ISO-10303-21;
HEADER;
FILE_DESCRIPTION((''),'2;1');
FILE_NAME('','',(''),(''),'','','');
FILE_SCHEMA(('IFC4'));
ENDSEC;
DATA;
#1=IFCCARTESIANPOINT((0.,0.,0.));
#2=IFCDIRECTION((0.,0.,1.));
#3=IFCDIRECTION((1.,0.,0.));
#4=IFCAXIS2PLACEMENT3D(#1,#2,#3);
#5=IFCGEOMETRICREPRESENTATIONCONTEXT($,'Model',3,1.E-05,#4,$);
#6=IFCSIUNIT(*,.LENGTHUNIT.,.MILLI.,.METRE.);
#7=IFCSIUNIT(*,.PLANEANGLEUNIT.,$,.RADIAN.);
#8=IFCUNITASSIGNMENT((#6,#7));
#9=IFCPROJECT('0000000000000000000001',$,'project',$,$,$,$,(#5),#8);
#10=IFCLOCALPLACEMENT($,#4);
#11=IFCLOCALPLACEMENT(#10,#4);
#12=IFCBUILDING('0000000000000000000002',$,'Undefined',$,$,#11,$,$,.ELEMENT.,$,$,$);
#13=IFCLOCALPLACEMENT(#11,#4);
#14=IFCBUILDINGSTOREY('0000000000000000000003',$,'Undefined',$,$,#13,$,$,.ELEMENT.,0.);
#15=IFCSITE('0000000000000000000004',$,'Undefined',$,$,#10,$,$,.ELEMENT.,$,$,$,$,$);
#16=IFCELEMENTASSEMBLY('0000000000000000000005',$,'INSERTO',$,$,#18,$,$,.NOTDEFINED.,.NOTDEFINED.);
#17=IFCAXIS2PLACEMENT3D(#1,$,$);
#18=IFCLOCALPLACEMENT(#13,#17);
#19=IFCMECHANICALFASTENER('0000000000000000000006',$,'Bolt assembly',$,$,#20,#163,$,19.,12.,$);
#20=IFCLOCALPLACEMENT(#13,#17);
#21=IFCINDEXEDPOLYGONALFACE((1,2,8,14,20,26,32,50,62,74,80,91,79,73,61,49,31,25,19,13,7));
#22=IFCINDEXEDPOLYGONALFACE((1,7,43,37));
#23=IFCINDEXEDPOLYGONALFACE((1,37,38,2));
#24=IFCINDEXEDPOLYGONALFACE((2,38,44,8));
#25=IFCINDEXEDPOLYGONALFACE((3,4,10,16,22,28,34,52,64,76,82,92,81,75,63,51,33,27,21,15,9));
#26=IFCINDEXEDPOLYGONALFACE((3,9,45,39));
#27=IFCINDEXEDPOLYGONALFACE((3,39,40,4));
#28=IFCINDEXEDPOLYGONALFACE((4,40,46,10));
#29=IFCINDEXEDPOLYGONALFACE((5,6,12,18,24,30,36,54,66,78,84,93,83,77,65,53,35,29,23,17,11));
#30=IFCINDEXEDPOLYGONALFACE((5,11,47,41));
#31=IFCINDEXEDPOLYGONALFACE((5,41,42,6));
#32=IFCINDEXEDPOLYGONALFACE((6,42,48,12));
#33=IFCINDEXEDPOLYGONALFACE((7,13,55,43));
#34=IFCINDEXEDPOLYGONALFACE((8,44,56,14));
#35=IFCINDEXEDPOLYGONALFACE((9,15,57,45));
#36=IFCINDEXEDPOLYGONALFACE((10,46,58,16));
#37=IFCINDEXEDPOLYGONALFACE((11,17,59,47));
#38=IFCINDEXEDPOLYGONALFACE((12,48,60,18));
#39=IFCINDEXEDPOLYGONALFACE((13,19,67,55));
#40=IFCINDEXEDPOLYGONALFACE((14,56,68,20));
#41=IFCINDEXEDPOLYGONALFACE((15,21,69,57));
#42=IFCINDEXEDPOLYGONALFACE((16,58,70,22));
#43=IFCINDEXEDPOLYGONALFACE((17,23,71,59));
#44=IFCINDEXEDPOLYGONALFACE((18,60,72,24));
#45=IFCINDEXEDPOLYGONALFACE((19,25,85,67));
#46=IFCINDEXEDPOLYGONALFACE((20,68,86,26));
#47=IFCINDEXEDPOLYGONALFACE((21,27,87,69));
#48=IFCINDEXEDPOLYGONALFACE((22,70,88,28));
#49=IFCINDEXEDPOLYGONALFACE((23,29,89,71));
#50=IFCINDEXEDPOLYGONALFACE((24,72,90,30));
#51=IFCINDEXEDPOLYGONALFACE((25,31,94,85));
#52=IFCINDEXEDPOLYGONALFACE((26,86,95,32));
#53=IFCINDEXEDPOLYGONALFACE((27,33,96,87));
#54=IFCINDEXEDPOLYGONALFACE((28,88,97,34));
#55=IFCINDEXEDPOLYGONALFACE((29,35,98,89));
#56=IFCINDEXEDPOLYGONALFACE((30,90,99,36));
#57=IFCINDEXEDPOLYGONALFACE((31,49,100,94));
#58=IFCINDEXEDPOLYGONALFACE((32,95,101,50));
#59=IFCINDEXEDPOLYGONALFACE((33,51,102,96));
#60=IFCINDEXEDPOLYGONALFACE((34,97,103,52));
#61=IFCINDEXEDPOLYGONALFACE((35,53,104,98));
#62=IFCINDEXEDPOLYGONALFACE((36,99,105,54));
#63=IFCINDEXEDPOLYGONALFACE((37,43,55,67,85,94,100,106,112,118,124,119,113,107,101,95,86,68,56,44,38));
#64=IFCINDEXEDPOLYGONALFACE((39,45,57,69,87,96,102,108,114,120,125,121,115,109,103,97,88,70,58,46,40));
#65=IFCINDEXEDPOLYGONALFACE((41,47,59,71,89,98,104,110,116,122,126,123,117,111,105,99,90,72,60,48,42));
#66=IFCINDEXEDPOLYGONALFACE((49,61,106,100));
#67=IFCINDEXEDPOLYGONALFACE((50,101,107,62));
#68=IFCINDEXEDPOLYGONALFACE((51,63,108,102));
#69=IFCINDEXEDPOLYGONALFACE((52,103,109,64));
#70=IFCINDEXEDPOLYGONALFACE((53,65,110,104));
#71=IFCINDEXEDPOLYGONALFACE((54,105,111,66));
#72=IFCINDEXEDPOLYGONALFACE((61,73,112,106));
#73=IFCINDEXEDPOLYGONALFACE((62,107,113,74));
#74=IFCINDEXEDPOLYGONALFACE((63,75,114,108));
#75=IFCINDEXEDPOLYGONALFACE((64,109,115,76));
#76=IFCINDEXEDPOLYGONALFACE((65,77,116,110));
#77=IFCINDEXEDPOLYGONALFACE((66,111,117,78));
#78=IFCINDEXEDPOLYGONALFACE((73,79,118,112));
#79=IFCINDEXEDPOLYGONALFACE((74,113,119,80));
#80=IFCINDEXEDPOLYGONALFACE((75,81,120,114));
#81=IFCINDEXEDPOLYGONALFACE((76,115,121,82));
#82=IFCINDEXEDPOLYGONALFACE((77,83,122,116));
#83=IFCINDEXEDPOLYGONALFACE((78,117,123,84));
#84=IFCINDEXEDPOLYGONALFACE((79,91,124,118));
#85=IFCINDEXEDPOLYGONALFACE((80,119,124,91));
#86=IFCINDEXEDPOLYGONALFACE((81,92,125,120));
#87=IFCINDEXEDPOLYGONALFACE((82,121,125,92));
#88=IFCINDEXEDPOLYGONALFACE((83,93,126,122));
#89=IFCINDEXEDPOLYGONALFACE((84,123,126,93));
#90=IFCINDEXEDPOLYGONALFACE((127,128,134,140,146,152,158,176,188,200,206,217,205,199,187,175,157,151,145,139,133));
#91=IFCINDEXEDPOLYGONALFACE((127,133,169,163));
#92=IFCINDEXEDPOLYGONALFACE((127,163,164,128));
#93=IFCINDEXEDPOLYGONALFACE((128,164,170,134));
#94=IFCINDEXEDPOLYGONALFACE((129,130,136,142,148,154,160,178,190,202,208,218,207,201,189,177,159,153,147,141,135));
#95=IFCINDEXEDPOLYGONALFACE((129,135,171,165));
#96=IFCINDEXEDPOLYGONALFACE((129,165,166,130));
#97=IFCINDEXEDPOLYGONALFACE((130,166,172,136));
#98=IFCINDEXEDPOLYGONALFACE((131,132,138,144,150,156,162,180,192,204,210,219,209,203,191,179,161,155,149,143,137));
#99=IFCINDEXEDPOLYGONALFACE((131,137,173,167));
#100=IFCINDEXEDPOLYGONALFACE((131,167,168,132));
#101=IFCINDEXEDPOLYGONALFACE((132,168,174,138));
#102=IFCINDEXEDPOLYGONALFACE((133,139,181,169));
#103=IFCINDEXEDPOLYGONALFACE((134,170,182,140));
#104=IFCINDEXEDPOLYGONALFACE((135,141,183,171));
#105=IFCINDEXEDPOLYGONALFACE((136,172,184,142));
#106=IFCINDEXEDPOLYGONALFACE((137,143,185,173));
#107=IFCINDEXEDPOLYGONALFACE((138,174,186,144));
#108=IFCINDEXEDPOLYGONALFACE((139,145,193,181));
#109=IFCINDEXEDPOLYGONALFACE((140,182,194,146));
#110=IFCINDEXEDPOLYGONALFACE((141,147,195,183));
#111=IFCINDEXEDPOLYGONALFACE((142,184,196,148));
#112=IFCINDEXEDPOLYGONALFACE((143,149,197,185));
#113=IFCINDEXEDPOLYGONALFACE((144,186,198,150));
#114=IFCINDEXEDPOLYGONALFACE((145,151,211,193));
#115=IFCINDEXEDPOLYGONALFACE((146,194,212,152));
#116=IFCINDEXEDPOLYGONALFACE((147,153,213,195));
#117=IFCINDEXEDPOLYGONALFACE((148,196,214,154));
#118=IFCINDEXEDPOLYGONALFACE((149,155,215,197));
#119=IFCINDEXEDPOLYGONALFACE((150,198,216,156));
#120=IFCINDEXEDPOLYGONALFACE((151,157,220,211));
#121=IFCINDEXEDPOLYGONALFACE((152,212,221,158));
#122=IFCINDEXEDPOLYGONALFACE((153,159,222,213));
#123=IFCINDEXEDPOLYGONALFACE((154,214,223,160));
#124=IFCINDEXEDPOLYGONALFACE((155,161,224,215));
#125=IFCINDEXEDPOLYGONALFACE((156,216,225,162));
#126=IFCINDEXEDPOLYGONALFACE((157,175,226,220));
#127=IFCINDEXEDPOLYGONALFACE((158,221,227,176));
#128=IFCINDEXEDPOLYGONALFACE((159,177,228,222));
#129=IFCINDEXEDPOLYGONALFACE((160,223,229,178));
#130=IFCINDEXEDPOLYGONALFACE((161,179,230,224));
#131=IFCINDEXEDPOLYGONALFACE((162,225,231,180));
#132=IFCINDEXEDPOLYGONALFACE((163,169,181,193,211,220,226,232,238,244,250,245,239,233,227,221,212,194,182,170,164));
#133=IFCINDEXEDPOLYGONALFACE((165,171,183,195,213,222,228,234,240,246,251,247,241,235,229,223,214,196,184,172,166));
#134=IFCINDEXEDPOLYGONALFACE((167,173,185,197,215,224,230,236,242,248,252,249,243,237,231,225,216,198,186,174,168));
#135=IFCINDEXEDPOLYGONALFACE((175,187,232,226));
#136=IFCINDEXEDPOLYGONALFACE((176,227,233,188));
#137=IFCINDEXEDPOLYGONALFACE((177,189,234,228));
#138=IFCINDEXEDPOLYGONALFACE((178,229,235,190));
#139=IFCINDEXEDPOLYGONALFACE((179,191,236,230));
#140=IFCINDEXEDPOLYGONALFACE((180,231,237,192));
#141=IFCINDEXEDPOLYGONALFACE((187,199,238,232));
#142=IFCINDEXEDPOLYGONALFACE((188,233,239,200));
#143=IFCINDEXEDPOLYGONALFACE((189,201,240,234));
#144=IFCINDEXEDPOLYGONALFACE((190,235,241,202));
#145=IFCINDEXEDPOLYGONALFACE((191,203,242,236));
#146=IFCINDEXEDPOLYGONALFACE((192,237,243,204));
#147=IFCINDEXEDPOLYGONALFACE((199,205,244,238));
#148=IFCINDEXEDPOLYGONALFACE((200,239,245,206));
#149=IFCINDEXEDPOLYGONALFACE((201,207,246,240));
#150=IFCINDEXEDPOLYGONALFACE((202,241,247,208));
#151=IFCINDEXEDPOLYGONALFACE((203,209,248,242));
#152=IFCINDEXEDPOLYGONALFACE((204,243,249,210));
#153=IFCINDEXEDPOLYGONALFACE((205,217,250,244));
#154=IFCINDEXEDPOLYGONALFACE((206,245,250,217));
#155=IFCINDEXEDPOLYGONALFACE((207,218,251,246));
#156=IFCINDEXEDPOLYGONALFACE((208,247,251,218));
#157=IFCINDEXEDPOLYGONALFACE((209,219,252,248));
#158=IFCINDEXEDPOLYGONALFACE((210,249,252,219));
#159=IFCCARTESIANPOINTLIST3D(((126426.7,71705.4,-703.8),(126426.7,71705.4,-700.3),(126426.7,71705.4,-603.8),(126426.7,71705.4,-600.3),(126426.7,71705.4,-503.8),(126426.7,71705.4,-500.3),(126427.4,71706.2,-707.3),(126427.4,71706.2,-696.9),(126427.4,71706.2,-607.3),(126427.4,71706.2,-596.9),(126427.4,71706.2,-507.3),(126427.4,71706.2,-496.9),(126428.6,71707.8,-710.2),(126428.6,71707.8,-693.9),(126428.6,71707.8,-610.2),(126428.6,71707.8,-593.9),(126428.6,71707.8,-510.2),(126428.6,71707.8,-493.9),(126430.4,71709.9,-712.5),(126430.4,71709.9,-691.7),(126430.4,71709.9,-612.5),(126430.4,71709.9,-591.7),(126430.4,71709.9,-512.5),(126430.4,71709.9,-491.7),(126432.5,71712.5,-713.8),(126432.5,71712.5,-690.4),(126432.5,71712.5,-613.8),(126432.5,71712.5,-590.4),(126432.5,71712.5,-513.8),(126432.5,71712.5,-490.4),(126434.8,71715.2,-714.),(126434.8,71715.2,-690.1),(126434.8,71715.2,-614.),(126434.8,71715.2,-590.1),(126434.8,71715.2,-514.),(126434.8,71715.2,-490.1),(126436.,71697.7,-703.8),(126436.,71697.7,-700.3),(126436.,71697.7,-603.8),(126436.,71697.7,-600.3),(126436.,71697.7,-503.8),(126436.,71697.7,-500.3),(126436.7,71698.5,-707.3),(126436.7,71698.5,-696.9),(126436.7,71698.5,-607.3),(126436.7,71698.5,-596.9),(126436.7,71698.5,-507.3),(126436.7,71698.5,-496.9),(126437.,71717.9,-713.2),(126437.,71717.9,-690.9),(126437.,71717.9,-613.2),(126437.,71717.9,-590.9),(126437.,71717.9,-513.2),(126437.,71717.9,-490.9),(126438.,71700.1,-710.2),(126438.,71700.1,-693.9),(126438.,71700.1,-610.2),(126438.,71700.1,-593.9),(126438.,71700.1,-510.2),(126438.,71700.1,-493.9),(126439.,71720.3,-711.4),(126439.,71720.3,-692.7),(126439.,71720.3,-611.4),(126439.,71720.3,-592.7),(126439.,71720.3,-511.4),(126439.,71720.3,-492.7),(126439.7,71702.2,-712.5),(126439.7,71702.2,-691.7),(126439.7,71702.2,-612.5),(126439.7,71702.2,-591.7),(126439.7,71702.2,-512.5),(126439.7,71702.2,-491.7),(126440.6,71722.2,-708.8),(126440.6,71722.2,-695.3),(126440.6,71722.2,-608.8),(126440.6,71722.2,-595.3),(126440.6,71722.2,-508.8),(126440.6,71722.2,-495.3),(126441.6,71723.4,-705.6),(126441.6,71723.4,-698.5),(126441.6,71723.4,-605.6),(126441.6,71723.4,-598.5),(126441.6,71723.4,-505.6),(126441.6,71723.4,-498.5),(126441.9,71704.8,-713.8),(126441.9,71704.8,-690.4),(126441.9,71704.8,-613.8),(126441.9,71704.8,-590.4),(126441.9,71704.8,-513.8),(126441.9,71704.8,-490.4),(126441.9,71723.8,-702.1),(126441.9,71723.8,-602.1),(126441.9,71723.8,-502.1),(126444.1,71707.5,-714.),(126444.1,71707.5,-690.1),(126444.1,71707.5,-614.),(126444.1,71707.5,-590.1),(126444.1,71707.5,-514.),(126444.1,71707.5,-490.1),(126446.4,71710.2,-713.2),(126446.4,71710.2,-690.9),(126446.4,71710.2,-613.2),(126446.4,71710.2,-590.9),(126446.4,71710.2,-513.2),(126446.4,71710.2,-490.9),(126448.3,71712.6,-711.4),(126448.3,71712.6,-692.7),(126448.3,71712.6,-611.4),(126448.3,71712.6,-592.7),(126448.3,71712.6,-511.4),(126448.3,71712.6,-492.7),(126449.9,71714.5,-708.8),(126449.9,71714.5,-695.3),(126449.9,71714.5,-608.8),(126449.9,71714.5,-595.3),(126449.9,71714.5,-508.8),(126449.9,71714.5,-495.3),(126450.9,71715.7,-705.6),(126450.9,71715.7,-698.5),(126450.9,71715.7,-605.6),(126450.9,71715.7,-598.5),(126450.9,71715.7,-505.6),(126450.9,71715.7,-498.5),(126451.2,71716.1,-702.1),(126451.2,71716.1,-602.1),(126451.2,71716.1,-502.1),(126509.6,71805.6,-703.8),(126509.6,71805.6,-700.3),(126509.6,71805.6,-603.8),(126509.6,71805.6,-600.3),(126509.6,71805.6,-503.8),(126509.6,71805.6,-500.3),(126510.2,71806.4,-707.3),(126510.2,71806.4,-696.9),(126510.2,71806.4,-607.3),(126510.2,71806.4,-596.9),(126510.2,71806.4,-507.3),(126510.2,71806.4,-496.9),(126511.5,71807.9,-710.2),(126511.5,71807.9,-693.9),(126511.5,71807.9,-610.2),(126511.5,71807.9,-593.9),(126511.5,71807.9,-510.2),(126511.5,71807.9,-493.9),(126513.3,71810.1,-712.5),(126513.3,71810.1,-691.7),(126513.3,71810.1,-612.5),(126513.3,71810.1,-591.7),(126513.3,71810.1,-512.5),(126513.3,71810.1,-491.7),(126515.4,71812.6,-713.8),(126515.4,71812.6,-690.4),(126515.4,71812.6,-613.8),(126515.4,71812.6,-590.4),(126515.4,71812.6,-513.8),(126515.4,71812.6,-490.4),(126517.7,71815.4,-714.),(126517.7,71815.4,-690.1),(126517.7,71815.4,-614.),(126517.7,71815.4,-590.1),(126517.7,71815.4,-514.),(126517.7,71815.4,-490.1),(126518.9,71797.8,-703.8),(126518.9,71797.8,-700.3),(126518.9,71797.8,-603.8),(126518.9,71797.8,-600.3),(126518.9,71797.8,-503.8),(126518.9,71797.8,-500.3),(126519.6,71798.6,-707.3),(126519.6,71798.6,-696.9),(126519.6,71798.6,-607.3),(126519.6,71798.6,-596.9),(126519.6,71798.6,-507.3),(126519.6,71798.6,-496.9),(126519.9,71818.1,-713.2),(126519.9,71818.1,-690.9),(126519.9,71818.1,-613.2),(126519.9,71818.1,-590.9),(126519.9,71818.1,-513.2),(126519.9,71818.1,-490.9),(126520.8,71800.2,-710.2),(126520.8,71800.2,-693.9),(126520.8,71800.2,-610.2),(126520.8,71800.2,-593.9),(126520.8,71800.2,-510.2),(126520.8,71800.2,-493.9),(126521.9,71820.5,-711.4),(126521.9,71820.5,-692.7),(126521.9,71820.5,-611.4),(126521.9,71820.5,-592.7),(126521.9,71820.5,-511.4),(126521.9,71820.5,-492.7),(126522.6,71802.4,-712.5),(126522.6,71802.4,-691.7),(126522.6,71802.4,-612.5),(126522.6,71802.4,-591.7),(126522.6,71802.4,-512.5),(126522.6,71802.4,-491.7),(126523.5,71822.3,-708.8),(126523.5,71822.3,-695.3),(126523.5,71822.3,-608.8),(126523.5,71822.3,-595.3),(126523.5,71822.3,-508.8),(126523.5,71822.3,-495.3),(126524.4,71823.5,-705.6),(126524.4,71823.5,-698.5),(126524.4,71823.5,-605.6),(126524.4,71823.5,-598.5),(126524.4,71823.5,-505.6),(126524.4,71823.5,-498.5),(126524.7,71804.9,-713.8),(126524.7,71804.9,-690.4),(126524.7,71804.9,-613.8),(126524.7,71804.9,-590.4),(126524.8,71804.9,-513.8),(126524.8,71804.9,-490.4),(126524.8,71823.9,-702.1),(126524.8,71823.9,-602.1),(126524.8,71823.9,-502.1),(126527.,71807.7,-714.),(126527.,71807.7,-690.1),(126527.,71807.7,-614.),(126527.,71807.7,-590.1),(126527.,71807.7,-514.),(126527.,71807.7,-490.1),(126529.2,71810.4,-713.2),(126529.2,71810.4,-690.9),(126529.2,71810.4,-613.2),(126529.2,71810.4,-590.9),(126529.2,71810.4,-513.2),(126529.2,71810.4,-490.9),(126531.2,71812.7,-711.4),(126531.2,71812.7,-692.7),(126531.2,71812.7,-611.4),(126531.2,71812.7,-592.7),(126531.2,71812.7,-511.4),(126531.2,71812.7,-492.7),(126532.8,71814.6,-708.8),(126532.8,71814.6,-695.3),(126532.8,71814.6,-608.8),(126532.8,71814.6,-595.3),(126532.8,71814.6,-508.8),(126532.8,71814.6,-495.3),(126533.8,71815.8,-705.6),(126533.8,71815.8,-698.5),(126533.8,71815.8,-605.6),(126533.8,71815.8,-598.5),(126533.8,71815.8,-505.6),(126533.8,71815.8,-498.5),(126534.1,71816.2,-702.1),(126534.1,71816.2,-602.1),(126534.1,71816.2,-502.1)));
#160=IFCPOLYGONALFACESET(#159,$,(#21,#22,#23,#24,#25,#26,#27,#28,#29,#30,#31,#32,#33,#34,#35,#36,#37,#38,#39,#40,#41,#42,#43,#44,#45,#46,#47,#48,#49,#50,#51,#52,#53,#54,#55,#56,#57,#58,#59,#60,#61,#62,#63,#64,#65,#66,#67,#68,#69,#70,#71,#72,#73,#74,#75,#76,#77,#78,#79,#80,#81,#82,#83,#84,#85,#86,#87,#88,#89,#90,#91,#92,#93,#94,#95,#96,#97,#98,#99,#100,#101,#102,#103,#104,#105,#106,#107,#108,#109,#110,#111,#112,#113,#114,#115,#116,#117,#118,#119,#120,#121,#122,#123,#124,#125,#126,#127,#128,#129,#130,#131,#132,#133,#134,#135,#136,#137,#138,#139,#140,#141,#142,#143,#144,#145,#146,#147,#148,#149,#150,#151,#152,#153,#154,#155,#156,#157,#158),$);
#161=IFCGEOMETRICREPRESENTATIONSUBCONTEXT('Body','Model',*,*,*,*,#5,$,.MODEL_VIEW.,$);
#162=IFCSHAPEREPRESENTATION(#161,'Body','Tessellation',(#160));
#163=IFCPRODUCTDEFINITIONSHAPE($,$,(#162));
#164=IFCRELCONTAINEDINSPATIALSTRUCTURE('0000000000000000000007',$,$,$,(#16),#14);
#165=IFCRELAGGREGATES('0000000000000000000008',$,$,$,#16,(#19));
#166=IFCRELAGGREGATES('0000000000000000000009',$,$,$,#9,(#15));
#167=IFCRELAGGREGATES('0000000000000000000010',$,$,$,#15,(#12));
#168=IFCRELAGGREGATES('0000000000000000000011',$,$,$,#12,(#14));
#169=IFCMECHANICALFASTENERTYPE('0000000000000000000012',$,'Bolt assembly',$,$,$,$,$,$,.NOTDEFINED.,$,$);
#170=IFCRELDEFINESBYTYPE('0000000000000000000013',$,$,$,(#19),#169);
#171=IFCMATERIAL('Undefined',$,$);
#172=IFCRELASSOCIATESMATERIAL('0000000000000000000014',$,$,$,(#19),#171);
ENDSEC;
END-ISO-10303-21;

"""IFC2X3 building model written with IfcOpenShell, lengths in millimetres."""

from ifc_helpers import new_model, si_unit, frame, origin_with_axes, origin_2d_with_axis, place, context, subcontext, project, spatial, circle, extrude, source, transform, mapped, material, type_object, element, aggregate, save


model = new_model("IFC2X3")

# Units and contexts
model_context = context("Model", 3, precision=1e-05, world=origin_with_axes())
body_context = subcontext(model_context, "Body", "Model", "MODEL_VIEW")
ifc_project = project(units=[si_unit("LENGTHUNIT", "METRE", prefix="MILLI"), si_unit("PLANEANGLEUNIT", "RADIAN")], contexts=[model_context])

# Site, building, storey
site_placement = place(None, origin_with_axes())
site = spatial("IfcSite", under=ifc_project, at=site_placement, Name="Undefined", CompositionType="ELEMENT")
building_placement = place(site_placement, origin_with_axes())
building = spatial("IfcBuilding", under=site, at=building_placement, Name="Undefined", CompositionType="ELEMENT")
storey_placement = place(building_placement, origin_with_axes())
storey = spatial("IfcBuildingStorey", under=building, at=storey_placement, Name="Undefined", CompositionType="ELEMENT", Elevation=0.0)

# Element assembly
assembly_1_placement = place(storey_placement, origin_with_axes())
assembly_1 = element("IfcElementAssembly", 1, at=assembly_1_placement, inside=storey, Name="INSERTO", AssemblyPlace="NOTDEFINED", PredefinedType="NOTDEFINED")

# Mechanical fastener
ifc_material_1 = material(Name="Undefined")
mechanical_fastener_type = type_object("IfcMechanicalFastenerType", Name="Bolt assembly")
shared_shape_1 = source(origin_with_axes(), body_context, "Body", "SweptSolid", [
    extrude(circle(Radius=12.0, at=origin_2d_with_axis()), frame((0.0, 0.0, 0.0), z_axis=(0.0, 1.0, 0.0), x_axis=(1.0, 0.0, 0.0)), (0.0, 0.0, 1.0), 12.1),
])
mechanical_fastener_1_placement = place(assembly_1_placement, frame((126443.6, 71706.8, -602.1), z_axis=(0.000001, 0.000001, 1.0), x_axis=(0.637563, 0.770399, -0.000002)))
mechanical_fastener_1 = element("IfcMechanicalFastener", 2, at=mechanical_fastener_1_placement, type_object=mechanical_fastener_type, material=ifc_material_1, Name="Bolt assembly", NominalDiameter=19.0, NominalLength=12.0, context=body_context, shape_type="MappedRepresentation", body=[
    mapped(shared_shape_1, transform((0.0, 0.0, -100.0))),
    mapped(shared_shape_1, transform((130.0, 0.0, -100.0))),
    mapped(shared_shape_1, transform((0.0, 0.0, 0.0))),
    mapped(shared_shape_1, transform((130.0, 0.0, 0.0))),
    mapped(shared_shape_1, transform((0.0, 0.0, 100.0))),
    mapped(shared_shape_1, transform((130.0, 0.0, 100.0))),
])
aggregate(assembly_1, [mechanical_fastener_1])

save(model, "model.ifc")
